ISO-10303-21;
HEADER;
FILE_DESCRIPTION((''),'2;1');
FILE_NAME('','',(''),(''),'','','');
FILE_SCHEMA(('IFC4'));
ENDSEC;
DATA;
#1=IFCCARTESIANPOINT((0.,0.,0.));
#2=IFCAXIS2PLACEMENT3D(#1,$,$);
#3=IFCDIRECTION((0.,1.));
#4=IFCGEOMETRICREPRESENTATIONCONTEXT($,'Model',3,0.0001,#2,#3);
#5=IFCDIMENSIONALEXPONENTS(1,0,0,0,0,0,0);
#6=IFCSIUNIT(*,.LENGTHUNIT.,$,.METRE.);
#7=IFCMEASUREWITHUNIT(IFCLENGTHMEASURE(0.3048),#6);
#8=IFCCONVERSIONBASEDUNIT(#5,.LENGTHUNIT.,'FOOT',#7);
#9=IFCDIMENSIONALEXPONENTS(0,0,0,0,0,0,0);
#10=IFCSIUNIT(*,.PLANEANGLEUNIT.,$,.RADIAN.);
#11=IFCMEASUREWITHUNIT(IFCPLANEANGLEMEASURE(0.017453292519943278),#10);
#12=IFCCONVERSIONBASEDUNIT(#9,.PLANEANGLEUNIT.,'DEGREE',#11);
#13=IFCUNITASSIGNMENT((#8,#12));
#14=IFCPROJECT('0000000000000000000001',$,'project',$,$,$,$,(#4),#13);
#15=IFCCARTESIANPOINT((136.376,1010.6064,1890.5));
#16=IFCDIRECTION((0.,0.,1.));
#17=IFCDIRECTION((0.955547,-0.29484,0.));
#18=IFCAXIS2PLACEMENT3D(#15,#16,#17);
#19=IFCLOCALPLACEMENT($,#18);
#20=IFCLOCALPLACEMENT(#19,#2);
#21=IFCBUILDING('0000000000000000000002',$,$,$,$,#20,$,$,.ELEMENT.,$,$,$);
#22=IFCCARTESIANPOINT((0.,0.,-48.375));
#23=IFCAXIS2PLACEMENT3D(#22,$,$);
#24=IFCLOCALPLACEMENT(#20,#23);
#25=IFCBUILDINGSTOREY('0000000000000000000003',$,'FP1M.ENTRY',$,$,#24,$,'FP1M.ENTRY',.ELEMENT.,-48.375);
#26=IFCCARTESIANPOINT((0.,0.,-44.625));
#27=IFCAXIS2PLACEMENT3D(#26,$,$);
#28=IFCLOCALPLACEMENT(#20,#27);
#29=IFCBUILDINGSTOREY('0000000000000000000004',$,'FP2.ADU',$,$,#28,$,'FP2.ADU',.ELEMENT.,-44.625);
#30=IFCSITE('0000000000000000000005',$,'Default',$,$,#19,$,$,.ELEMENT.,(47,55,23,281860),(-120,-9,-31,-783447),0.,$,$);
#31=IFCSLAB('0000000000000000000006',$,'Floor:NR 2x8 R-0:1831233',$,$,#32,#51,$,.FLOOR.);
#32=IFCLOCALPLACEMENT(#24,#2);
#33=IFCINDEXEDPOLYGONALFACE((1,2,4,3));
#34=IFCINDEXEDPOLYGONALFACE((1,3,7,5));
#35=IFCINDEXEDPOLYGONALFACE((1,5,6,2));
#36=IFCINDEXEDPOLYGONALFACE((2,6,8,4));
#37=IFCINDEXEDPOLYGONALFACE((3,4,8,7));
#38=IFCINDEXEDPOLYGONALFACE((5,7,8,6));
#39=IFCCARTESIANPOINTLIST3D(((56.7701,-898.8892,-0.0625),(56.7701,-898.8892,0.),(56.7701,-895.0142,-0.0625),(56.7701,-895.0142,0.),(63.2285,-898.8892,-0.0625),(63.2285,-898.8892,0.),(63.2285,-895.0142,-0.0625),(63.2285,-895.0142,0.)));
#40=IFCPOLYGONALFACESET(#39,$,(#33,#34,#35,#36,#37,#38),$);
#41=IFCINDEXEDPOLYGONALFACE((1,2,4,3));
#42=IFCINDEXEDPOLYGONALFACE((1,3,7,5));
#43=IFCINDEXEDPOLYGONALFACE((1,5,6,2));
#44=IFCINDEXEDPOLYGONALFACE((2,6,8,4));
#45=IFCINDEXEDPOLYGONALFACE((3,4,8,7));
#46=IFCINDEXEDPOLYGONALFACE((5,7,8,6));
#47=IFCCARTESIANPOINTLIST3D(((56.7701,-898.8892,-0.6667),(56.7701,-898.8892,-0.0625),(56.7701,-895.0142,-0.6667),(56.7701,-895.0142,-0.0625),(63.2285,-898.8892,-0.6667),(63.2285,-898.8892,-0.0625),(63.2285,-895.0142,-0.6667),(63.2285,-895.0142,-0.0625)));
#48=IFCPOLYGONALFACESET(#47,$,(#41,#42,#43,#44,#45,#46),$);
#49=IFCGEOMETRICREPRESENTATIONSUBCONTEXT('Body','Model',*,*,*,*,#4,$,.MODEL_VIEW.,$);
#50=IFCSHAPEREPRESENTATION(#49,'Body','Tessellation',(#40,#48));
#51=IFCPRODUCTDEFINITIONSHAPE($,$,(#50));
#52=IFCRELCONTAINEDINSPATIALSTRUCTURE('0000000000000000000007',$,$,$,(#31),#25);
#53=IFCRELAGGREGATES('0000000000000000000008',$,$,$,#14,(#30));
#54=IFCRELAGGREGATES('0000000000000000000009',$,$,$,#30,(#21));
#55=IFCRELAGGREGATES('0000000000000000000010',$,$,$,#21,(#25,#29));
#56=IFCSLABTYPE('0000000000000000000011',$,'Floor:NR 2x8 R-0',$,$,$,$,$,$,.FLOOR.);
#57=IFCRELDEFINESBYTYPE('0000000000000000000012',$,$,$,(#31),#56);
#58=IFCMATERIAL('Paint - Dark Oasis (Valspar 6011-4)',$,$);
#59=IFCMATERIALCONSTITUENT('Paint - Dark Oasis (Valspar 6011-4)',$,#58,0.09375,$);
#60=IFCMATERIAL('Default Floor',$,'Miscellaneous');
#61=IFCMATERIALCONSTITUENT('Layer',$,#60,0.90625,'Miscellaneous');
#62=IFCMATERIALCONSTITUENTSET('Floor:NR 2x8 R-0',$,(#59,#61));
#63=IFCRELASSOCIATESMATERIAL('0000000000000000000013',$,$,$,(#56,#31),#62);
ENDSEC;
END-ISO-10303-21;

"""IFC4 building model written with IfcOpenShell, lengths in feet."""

from ifc_helpers import new_model, entity, si_unit, converted_unit, direction, frame, origin, place, context, subcontext, project, spatial, indexed_curve, outline, extrude, material, constituent, constituent_set, type_object, element, save


model = new_model("IFC4")

# Units and contexts
model_context = context("Model", 3, precision=0.0001, world=origin(), true_north=direction((0.0, 1.0)))
body_context = subcontext(model_context, "Body", "Model", "MODEL_VIEW")
ifc_project = project(units=[converted_unit("LENGTHUNIT", "FOOT", entity("IfcLengthMeasure", 0.3048), si_unit("LENGTHUNIT", "METRE"), dimensions=[1, 0, 0, 0, 0, 0, 0]), converted_unit("PLANEANGLEUNIT", "DEGREE", entity("IfcPlaneAngleMeasure", 0.017453292519943278), si_unit("PLANEANGLEUNIT", "RADIAN"), dimensions=[0, 0, 0, 0, 0, 0, 0])], contexts=[model_context])

# Site, building, storey
site_placement = place(None, frame((136.376, 1010.6064, 1890.5), z_axis=(0.0, 0.0, 1.0), x_axis=(0.955547, -0.29484, 0.0)))
site = spatial("IfcSite", under=ifc_project, at=site_placement, Name="Default", CompositionType="ELEMENT", RefLatitude=(47, 55, 23, 281860), RefLongitude=(-120, -9, -31, -783447), RefElevation=0.0)
building_placement = place(site_placement, origin())
building = spatial("IfcBuilding", under=site, at=building_placement, CompositionType="ELEMENT")
storey_1_placement = place(building_placement, frame((0.0, 0.0, -48.375)))
storey_1 = spatial("IfcBuildingStorey", under=building, at=storey_1_placement, Name="FP1M.ENTRY", LongName="FP1M.ENTRY", CompositionType="ELEMENT", Elevation=-48.375)

# Slab
ifc_material_1 = material(Name="Paint - Dark Oasis (Valspar 6011-4)")
ifc_constituent_1 = constituent(ifc_material_1, Name="Paint - Dark Oasis (Valspar 6011-4)", fraction=0.09375)
ifc_material_2 = material(Name="Default Floor", Category="Miscellaneous")
ifc_constituent_2 = constituent(ifc_material_2, Name="Layer", Category="Miscellaneous", fraction=0.90625)
ifc_constituent_set_1 = constituent_set(constituents=[ifc_constituent_1, ifc_constituent_2], Name="Floor:NR 2x8 R-0")
slab_type = type_object("IfcSlabType", Name="Floor:NR 2x8 R-0", PredefinedType="FLOOR", material=ifc_constituent_set_1)
slab_placement = place(storey_1_placement, origin())
element("IfcSlab", 1, at=slab_placement, inside=storey_1, type_object=slab_type, material=ifc_constituent_set_1, Name="Floor:NR 2x8 R-0:1831233", PredefinedType="FLOOR", context=body_context, shape_type="SweptSolid", body=[
    extrude(outline(indexed_curve([(-3.2292, -1.9375), (3.2292, -1.9375), (3.2292, 1.9375), (-3.2292, 1.9375), (-3.2292, -1.9375)], self_intersect=False)), frame((59.9993, -896.9517, -0.0625), z_axis=(0.0, 0.0, 1.0), x_axis=(-1.0, 0.0, 0.0)), (0.0, 0.0, 1.0), 0.0625),
    extrude(outline(indexed_curve([(-3.2292, -1.9375), (3.2292, -1.9375), (3.2292, 1.9375), (-3.2292, 1.9375), (-3.2292, -1.9375)], self_intersect=False)), frame((59.9993, -896.9517, -0.6667), z_axis=(0.0, 0.0, 1.0), x_axis=(-1.0, 0.0, 0.0)), (0.0, 0.0, 1.0), 0.6042),
])

# Shared definitions
storey_2_placement = place(building_placement, frame((0.0, 0.0, -44.625)))
storey_2 = spatial("IfcBuildingStorey", under=building, at=storey_2_placement, Name="FP2.ADU", LongName="FP2.ADU", CompositionType="ELEMENT", Elevation=-44.625)

save(model, "model.ifc")
